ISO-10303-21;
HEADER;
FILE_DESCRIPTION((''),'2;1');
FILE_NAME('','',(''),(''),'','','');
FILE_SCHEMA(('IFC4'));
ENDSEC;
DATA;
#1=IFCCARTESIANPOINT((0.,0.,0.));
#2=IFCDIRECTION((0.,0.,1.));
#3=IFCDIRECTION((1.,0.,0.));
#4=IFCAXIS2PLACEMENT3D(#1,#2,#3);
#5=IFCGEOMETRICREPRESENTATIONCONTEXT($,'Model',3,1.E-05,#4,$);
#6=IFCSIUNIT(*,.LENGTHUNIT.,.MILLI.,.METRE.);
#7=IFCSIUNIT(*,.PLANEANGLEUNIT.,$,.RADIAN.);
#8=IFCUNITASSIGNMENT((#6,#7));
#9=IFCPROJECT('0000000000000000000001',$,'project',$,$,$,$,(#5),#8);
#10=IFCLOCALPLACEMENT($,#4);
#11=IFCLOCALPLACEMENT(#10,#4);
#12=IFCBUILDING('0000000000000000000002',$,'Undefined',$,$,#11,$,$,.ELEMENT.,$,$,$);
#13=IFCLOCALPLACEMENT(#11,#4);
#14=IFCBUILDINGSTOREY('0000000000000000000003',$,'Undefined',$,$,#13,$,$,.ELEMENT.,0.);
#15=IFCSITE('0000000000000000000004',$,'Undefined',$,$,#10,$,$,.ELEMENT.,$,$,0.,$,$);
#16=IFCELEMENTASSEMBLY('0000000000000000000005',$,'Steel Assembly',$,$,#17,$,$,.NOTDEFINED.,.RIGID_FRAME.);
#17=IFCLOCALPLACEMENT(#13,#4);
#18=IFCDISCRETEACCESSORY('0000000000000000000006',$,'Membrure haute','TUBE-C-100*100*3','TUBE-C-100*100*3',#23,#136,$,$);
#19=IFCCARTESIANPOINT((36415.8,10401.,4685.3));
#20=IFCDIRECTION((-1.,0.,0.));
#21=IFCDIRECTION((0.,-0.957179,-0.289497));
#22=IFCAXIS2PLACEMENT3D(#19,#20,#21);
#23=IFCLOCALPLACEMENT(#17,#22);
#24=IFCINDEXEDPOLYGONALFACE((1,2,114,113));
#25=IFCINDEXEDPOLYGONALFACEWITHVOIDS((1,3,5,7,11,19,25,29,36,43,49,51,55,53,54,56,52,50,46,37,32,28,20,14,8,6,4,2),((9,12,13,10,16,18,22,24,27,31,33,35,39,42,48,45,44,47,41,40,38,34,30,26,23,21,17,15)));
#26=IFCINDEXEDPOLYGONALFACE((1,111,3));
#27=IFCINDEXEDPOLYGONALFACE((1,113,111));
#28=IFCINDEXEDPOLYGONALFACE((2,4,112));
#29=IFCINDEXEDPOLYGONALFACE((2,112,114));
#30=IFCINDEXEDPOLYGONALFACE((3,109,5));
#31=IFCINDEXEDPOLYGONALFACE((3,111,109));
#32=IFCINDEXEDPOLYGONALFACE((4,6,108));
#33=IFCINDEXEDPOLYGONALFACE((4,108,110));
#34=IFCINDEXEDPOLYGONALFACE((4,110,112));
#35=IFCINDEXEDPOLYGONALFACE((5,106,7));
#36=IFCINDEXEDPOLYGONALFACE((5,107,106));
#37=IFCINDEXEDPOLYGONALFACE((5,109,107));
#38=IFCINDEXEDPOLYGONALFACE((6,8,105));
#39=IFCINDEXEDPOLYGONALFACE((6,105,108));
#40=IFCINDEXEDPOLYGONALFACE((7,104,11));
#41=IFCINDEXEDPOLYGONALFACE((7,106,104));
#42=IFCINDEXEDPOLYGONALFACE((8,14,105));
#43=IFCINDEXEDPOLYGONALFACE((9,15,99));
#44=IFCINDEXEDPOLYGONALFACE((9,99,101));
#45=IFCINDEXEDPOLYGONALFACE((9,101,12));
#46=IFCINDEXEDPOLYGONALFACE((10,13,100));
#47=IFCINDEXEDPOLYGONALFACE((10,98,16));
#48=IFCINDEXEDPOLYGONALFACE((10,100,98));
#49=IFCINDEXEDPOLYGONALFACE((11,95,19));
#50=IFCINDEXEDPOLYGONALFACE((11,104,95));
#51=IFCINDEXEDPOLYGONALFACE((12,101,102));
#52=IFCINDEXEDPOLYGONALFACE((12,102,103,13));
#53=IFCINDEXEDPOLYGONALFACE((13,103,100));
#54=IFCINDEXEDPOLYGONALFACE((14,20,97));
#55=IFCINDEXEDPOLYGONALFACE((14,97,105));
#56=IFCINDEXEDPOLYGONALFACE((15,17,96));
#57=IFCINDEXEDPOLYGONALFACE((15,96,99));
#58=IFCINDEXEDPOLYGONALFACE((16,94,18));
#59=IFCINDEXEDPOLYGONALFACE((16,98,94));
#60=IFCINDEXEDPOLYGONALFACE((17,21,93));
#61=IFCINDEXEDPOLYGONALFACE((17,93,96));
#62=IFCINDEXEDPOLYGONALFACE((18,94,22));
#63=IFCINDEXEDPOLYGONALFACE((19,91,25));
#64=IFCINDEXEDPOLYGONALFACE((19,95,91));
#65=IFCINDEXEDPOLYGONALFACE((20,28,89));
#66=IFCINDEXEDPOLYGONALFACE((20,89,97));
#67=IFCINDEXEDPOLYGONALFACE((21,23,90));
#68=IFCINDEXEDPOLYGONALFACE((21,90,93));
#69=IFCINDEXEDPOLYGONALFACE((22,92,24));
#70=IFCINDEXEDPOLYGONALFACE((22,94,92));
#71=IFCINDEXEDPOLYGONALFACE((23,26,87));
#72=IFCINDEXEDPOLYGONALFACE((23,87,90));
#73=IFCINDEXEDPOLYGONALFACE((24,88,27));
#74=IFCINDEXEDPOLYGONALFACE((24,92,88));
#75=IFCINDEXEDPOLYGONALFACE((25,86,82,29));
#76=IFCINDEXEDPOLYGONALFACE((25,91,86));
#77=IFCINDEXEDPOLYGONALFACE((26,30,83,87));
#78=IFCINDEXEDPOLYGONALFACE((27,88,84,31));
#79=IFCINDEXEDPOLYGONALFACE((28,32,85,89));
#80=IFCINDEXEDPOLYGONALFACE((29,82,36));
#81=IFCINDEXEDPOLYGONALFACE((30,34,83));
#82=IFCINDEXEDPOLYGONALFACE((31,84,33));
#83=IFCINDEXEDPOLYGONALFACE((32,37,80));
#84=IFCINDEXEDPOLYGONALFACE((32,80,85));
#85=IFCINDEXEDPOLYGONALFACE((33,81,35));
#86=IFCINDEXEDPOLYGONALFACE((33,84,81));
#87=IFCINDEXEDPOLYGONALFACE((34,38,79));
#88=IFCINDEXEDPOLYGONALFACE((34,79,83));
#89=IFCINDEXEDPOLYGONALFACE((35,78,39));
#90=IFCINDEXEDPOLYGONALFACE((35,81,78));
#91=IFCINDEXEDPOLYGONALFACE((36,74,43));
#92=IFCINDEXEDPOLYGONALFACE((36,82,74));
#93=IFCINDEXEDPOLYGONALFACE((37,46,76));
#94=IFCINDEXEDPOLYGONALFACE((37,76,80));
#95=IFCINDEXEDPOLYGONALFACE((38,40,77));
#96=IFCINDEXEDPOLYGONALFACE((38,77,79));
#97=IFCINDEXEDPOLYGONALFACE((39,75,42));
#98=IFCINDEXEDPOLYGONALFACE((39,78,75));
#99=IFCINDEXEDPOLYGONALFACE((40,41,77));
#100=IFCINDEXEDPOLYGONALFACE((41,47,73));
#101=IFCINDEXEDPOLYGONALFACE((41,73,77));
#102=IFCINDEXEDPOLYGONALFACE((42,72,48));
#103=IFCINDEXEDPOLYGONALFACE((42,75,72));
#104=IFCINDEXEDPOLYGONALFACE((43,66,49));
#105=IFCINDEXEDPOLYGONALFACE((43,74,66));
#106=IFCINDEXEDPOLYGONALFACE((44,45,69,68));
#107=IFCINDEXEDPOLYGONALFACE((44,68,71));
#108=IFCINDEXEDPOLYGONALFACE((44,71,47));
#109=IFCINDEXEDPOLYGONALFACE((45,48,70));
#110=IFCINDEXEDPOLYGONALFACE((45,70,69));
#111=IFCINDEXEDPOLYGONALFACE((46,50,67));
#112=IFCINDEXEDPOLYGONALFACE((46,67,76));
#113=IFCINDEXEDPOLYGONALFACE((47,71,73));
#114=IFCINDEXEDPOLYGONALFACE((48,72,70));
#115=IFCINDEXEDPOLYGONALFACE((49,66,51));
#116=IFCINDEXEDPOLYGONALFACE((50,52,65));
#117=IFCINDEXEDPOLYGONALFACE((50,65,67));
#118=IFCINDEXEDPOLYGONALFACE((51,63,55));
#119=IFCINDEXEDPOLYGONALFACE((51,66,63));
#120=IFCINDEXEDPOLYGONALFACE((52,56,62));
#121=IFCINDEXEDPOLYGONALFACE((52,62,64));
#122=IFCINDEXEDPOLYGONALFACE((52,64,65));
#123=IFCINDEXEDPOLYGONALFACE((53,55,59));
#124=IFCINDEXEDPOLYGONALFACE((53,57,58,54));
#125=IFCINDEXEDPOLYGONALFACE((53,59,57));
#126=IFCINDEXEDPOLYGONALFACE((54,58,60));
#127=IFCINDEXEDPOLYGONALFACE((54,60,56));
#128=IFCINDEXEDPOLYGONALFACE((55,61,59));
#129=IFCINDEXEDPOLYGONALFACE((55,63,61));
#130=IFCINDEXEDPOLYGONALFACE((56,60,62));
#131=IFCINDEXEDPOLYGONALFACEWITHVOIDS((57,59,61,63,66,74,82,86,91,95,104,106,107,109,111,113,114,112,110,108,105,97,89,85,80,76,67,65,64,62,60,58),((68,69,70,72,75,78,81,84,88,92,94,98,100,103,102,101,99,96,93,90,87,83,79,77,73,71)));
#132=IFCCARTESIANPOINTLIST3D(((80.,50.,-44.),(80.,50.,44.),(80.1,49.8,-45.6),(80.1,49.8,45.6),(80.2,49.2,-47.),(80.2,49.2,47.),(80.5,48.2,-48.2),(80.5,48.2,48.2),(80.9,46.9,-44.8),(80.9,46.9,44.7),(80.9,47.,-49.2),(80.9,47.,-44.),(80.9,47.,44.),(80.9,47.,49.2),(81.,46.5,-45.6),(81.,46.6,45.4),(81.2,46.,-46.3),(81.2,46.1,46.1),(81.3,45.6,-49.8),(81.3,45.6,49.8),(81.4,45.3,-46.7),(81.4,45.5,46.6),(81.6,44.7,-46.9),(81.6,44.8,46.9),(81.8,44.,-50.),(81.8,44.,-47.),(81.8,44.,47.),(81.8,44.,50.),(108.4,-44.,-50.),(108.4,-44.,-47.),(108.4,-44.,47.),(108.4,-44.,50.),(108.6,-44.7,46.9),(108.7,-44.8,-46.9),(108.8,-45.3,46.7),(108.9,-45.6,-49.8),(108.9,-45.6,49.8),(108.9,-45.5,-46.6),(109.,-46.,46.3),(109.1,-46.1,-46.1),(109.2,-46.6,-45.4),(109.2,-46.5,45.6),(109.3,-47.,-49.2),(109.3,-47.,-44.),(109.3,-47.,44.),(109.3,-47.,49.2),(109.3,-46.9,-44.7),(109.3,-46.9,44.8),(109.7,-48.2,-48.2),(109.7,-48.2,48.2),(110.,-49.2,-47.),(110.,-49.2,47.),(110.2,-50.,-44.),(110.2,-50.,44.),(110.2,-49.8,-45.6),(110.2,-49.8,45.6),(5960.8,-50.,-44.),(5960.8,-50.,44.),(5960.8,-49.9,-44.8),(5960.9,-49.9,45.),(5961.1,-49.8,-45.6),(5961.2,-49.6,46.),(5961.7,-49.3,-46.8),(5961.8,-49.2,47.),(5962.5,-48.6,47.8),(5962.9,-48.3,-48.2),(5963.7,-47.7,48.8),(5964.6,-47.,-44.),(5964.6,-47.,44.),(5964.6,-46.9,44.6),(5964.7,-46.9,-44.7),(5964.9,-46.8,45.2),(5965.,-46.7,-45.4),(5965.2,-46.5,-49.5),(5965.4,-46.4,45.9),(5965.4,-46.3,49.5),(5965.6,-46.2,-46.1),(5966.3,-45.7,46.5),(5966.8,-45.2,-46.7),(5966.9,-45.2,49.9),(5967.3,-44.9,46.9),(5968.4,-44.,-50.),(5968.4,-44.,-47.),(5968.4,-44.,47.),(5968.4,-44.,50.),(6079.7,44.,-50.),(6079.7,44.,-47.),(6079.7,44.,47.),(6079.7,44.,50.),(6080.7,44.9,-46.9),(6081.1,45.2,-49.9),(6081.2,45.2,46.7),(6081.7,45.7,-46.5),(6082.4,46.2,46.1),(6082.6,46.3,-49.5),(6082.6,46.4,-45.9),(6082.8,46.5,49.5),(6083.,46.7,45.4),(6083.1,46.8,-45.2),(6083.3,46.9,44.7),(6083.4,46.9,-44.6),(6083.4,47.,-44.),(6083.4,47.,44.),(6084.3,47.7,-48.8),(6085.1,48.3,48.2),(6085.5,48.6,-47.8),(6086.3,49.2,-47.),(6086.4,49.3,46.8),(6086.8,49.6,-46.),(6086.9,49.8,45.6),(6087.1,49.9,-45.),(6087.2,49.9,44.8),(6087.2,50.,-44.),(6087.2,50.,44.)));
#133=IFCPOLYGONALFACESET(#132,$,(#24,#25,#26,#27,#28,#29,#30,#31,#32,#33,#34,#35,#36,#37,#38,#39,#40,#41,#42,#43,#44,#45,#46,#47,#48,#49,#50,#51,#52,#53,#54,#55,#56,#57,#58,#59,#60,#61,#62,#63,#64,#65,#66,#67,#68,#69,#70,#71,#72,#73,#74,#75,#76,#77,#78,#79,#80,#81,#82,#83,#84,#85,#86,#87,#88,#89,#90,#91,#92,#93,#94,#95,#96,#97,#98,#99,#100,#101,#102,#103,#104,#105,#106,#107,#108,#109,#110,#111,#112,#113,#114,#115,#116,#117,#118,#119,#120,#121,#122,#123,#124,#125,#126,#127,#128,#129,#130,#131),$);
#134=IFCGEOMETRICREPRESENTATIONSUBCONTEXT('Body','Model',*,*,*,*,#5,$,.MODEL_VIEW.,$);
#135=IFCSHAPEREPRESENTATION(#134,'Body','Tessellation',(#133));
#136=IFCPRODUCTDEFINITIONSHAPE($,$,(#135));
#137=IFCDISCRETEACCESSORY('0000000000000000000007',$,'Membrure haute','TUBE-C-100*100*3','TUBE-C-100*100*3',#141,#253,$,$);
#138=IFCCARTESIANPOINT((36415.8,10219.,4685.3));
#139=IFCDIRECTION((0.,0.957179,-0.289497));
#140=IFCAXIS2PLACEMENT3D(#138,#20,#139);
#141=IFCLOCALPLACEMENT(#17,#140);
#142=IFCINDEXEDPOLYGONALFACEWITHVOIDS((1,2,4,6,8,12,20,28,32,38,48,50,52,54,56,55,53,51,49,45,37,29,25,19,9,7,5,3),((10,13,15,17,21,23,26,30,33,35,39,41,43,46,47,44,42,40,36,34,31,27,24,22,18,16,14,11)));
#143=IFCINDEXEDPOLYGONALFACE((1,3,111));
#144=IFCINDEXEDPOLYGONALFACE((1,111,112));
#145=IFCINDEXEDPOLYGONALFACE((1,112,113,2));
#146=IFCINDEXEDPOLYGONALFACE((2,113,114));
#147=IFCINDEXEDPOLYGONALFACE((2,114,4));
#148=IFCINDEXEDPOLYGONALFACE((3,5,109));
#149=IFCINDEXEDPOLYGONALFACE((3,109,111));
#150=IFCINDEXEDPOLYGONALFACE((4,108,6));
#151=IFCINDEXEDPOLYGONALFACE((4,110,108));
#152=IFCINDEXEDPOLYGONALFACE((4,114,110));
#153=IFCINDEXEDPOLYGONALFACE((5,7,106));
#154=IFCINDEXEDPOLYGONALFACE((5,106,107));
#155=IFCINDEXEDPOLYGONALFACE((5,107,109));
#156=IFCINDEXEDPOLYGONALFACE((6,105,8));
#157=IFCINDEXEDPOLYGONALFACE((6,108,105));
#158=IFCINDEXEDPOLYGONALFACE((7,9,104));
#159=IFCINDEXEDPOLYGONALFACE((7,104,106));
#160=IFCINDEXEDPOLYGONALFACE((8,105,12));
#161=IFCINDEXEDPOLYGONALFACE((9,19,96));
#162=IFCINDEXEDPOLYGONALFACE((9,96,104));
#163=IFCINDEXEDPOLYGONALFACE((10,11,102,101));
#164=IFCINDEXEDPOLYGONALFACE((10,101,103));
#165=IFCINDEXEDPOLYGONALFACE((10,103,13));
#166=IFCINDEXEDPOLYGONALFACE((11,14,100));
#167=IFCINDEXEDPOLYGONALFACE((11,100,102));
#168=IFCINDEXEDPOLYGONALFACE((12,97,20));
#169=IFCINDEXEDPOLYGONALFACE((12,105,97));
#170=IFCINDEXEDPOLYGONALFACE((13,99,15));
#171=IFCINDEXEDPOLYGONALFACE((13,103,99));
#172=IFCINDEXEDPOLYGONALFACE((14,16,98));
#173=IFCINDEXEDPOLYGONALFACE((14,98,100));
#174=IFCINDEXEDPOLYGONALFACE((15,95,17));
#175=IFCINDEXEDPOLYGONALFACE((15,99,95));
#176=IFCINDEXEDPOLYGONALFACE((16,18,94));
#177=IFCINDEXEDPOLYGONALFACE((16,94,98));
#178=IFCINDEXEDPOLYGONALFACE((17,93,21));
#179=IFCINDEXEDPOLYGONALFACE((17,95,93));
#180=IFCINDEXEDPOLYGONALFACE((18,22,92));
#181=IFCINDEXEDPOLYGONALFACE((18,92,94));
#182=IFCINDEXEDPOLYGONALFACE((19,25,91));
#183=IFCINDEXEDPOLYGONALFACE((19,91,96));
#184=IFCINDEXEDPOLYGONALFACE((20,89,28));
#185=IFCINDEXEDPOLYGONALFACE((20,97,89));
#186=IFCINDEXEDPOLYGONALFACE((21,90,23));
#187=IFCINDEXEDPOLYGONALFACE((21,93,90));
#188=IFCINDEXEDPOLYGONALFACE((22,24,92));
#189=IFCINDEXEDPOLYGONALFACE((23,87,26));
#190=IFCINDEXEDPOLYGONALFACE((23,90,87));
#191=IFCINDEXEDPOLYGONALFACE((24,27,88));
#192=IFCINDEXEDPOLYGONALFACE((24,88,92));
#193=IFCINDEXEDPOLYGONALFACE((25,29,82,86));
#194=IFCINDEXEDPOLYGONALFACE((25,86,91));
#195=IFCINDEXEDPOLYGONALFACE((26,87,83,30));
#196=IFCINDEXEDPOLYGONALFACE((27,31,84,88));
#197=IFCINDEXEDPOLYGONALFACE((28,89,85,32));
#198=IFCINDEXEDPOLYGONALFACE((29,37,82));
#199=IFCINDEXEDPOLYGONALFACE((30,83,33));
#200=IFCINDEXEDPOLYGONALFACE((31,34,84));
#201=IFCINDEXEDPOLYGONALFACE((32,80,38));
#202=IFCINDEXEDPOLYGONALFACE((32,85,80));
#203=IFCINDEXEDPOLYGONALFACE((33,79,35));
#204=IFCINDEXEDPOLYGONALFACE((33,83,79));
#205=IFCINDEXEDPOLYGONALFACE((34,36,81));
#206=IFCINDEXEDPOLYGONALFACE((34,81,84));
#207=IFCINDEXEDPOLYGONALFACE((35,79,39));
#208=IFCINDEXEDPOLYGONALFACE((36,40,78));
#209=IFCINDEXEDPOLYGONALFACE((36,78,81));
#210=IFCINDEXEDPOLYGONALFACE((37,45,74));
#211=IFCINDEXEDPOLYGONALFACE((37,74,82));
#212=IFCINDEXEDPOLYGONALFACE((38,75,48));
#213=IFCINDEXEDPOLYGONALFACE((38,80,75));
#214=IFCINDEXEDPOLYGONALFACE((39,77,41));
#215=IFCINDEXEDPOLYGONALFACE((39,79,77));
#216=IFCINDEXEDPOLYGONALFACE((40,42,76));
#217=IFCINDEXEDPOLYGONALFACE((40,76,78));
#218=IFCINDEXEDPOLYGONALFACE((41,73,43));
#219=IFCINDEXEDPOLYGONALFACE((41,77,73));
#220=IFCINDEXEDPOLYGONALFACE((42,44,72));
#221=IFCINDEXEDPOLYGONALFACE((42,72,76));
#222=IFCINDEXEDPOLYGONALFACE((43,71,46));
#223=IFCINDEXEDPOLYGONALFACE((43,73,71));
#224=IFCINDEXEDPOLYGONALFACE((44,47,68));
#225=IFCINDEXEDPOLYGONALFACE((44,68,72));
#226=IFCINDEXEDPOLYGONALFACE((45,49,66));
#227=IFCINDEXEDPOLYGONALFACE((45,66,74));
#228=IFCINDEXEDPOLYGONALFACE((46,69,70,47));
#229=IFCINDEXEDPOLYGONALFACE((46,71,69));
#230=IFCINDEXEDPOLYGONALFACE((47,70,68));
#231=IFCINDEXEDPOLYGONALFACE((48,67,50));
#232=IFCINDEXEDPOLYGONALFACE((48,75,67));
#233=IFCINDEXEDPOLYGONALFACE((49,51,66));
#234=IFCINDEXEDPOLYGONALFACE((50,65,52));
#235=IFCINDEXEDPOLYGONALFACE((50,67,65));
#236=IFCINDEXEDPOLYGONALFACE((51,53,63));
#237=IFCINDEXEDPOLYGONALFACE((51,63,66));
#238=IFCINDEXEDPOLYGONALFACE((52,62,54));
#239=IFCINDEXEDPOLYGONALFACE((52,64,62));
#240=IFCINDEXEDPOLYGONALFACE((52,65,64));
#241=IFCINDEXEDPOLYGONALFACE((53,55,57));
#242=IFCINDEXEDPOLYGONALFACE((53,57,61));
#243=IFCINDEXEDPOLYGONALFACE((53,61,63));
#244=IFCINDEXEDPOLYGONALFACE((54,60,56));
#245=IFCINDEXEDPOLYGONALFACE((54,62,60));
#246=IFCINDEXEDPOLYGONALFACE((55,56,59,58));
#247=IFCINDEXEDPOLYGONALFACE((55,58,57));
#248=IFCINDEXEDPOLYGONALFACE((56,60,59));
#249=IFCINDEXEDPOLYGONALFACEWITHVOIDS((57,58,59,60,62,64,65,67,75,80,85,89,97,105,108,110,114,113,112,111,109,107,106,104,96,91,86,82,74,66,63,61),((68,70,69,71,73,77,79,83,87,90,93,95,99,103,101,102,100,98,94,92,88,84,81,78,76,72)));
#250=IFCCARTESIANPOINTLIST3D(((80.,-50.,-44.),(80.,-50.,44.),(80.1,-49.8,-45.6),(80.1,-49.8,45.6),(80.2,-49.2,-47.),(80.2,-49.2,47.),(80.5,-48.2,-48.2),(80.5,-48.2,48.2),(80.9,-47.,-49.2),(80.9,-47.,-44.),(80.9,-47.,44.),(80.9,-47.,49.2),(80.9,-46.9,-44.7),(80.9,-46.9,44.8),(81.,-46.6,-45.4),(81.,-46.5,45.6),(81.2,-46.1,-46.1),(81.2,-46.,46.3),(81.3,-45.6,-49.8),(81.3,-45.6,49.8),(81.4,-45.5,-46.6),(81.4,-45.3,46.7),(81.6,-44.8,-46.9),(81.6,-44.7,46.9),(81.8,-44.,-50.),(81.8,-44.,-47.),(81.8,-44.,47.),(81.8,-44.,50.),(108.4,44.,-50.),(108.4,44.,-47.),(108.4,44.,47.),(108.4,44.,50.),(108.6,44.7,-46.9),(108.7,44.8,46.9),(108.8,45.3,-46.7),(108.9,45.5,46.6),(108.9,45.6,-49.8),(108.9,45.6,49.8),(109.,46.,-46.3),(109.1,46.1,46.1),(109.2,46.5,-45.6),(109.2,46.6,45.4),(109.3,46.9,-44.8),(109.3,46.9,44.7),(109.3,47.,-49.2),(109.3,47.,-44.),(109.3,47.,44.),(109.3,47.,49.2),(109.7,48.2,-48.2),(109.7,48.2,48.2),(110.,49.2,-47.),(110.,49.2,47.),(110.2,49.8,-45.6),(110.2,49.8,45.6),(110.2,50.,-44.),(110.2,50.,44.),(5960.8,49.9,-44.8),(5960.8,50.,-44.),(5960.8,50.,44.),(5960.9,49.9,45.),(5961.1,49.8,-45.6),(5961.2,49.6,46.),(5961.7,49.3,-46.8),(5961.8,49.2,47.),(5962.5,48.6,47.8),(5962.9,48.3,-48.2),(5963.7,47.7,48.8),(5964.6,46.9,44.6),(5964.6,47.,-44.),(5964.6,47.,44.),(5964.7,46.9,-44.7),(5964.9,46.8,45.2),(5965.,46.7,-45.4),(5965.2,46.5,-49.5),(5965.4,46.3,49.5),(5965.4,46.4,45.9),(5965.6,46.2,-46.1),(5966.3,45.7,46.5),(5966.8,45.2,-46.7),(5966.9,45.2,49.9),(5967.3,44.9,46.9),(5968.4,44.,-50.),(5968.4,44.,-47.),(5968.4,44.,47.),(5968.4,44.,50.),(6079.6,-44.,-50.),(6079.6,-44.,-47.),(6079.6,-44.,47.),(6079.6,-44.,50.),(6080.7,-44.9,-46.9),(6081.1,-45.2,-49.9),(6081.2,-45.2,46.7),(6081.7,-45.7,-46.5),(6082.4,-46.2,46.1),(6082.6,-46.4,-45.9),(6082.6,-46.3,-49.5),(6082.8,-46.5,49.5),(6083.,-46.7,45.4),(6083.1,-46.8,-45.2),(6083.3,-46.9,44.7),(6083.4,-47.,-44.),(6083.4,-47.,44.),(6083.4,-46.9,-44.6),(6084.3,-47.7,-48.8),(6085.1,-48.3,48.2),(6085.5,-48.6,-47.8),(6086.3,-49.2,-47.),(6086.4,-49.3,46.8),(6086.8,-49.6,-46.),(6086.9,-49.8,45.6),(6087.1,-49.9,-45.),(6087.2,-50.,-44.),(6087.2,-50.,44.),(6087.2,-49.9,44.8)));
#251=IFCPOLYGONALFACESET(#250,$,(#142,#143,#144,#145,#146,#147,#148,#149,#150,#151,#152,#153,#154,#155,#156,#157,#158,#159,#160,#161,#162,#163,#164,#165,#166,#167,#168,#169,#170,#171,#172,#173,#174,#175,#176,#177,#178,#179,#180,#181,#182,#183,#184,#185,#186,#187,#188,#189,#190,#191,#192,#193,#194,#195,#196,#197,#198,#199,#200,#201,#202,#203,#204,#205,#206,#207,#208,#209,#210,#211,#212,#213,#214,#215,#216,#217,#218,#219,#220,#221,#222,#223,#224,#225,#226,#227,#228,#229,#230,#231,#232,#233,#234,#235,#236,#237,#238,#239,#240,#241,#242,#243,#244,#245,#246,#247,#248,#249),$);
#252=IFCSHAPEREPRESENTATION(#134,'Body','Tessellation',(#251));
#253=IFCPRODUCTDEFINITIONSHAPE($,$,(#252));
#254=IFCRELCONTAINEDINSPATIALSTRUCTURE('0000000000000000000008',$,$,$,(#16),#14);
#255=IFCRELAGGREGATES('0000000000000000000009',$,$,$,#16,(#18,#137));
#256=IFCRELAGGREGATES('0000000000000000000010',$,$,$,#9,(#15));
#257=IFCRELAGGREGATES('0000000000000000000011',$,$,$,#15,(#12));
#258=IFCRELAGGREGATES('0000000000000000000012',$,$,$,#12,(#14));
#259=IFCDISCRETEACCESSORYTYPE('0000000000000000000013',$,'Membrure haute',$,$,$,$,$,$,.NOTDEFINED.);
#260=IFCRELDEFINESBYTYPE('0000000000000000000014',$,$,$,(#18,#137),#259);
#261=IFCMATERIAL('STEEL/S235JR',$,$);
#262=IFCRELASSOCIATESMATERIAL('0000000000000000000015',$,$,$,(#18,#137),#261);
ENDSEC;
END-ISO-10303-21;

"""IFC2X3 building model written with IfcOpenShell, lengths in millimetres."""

from ifc_helpers import new_model, si_unit, frame, origin_with_axes, origin_2d_with_axis, place, context, subcontext, project, spatial, hollow_rectangle, extrude, clip, halfspace, material, type_object, element, aggregate, save


model = new_model("IFC2X3")

# Units and contexts
model_context = context("Model", 3, precision=1e-05, world=origin_with_axes())
body_context = subcontext(model_context, "Body", "Model", "MODEL_VIEW")
ifc_project = project(units=[si_unit("LENGTHUNIT", "METRE", prefix="MILLI"), si_unit("PLANEANGLEUNIT", "RADIAN")], contexts=[model_context])

# Site, building, storey
site_placement = place(None, origin_with_axes())
site = spatial("IfcSite", under=ifc_project, at=site_placement, Name="Undefined", CompositionType="ELEMENT", RefElevation=0.0)
building_placement = place(site_placement, origin_with_axes())
building = spatial("IfcBuilding", under=site, at=building_placement, Name="Undefined", CompositionType="ELEMENT")
storey_placement = place(building_placement, origin_with_axes())
storey = spatial("IfcBuildingStorey", under=building, at=storey_placement, Name="Undefined", CompositionType="ELEMENT", Elevation=0.0)

# Shared definitions
ifc_material_1 = material(Name="STEEL/S235JR")

# Element assembly, discrete accessories
assembly_1_placement = place(storey_placement, origin_with_axes())
assembly_1 = element("IfcElementAssembly", 1, at=assembly_1_placement, inside=storey, Name="Steel Assembly", AssemblyPlace="NOTDEFINED", PredefinedType="RIGID_FRAME")
discrete_accessory_type_1 = type_object("IfcDiscreteAccessoryType", Name="Membrure haute")
discrete_accessory_1_placement = place(assembly_1_placement, frame((36415.8, 10401.0, 4685.3), z_axis=(-1.0, 0.0, 0.0), x_axis=(0.0, -0.957179, -0.289497)))
discrete_accessory_1 = element("IfcDiscreteAccessory", 2, at=discrete_accessory_1_placement, type_object=discrete_accessory_type_1, material=ifc_material_1, Name="Membrure haute", Description="TUBE-C-100*100*3", ObjectType="TUBE-C-100*100*3", context=body_context, shape_type="Clipping", body=[
    clip(clip(extrude(hollow_rectangle(XDim=100.0, YDim=100.0, WallThickness=3.0, InnerFilletRadius=3.0, OuterFilletRadius=6.0, at=origin_2d_with_axis()), frame((6120.4, 0.0, 0.0), z_axis=(-1.0, 0.0, 0.0), x_axis=(0.0, -1.0, 0.0)), (0.0, 0.0, 1.0), 6121.7), halfspace(frame((5960.8, -50.0, -50.0), z_axis=(-0.620241, 0.784411, 0.0), x_axis=(0.0, 0.0, -1.0)), True)), halfspace(frame((64.4, 101.5, 0.0), z_axis=(-0.957179, -0.289497, 0.0), x_axis=(0.289497, -0.957179, 0.0)), False)),
])
discrete_accessory_2_placement = place(assembly_1_placement, frame((36415.8, 10219.0, 4685.3), z_axis=(-1.0, 0.0, 0.0), x_axis=(0.0, 0.957179, -0.289497)))
discrete_accessory_2 = element("IfcDiscreteAccessory", 3, at=discrete_accessory_2_placement, type_object=discrete_accessory_type_1, material=ifc_material_1, Name="Membrure haute", Description="TUBE-C-100*100*3", ObjectType="TUBE-C-100*100*3", context=body_context, shape_type="Clipping", body=[
    clip(clip(extrude(hollow_rectangle(XDim=100.0, YDim=100.0, WallThickness=3.0, InnerFilletRadius=3.0, OuterFilletRadius=6.0, at=origin_2d_with_axis()), frame((6120.4, 0.0, 0.0), z_axis=(-1.0, 0.0, 0.0), x_axis=(0.0, -1.0, 0.0)), (0.0, 0.0, 1.0), 6121.7), halfspace(frame((5960.8, 50.0, -50.0), z_axis=(0.62025, 0.784404, 0.0), x_axis=(0.0, 0.0, -1.0)), False)), halfspace(frame((64.4, -101.5, 0.0), z_axis=(-0.957179, 0.289497, 0.0), x_axis=(0.0, 0.0, -1.0)), False)),
])
aggregate(assembly_1, [discrete_accessory_1, discrete_accessory_2])

save(model, "model.ifc")
